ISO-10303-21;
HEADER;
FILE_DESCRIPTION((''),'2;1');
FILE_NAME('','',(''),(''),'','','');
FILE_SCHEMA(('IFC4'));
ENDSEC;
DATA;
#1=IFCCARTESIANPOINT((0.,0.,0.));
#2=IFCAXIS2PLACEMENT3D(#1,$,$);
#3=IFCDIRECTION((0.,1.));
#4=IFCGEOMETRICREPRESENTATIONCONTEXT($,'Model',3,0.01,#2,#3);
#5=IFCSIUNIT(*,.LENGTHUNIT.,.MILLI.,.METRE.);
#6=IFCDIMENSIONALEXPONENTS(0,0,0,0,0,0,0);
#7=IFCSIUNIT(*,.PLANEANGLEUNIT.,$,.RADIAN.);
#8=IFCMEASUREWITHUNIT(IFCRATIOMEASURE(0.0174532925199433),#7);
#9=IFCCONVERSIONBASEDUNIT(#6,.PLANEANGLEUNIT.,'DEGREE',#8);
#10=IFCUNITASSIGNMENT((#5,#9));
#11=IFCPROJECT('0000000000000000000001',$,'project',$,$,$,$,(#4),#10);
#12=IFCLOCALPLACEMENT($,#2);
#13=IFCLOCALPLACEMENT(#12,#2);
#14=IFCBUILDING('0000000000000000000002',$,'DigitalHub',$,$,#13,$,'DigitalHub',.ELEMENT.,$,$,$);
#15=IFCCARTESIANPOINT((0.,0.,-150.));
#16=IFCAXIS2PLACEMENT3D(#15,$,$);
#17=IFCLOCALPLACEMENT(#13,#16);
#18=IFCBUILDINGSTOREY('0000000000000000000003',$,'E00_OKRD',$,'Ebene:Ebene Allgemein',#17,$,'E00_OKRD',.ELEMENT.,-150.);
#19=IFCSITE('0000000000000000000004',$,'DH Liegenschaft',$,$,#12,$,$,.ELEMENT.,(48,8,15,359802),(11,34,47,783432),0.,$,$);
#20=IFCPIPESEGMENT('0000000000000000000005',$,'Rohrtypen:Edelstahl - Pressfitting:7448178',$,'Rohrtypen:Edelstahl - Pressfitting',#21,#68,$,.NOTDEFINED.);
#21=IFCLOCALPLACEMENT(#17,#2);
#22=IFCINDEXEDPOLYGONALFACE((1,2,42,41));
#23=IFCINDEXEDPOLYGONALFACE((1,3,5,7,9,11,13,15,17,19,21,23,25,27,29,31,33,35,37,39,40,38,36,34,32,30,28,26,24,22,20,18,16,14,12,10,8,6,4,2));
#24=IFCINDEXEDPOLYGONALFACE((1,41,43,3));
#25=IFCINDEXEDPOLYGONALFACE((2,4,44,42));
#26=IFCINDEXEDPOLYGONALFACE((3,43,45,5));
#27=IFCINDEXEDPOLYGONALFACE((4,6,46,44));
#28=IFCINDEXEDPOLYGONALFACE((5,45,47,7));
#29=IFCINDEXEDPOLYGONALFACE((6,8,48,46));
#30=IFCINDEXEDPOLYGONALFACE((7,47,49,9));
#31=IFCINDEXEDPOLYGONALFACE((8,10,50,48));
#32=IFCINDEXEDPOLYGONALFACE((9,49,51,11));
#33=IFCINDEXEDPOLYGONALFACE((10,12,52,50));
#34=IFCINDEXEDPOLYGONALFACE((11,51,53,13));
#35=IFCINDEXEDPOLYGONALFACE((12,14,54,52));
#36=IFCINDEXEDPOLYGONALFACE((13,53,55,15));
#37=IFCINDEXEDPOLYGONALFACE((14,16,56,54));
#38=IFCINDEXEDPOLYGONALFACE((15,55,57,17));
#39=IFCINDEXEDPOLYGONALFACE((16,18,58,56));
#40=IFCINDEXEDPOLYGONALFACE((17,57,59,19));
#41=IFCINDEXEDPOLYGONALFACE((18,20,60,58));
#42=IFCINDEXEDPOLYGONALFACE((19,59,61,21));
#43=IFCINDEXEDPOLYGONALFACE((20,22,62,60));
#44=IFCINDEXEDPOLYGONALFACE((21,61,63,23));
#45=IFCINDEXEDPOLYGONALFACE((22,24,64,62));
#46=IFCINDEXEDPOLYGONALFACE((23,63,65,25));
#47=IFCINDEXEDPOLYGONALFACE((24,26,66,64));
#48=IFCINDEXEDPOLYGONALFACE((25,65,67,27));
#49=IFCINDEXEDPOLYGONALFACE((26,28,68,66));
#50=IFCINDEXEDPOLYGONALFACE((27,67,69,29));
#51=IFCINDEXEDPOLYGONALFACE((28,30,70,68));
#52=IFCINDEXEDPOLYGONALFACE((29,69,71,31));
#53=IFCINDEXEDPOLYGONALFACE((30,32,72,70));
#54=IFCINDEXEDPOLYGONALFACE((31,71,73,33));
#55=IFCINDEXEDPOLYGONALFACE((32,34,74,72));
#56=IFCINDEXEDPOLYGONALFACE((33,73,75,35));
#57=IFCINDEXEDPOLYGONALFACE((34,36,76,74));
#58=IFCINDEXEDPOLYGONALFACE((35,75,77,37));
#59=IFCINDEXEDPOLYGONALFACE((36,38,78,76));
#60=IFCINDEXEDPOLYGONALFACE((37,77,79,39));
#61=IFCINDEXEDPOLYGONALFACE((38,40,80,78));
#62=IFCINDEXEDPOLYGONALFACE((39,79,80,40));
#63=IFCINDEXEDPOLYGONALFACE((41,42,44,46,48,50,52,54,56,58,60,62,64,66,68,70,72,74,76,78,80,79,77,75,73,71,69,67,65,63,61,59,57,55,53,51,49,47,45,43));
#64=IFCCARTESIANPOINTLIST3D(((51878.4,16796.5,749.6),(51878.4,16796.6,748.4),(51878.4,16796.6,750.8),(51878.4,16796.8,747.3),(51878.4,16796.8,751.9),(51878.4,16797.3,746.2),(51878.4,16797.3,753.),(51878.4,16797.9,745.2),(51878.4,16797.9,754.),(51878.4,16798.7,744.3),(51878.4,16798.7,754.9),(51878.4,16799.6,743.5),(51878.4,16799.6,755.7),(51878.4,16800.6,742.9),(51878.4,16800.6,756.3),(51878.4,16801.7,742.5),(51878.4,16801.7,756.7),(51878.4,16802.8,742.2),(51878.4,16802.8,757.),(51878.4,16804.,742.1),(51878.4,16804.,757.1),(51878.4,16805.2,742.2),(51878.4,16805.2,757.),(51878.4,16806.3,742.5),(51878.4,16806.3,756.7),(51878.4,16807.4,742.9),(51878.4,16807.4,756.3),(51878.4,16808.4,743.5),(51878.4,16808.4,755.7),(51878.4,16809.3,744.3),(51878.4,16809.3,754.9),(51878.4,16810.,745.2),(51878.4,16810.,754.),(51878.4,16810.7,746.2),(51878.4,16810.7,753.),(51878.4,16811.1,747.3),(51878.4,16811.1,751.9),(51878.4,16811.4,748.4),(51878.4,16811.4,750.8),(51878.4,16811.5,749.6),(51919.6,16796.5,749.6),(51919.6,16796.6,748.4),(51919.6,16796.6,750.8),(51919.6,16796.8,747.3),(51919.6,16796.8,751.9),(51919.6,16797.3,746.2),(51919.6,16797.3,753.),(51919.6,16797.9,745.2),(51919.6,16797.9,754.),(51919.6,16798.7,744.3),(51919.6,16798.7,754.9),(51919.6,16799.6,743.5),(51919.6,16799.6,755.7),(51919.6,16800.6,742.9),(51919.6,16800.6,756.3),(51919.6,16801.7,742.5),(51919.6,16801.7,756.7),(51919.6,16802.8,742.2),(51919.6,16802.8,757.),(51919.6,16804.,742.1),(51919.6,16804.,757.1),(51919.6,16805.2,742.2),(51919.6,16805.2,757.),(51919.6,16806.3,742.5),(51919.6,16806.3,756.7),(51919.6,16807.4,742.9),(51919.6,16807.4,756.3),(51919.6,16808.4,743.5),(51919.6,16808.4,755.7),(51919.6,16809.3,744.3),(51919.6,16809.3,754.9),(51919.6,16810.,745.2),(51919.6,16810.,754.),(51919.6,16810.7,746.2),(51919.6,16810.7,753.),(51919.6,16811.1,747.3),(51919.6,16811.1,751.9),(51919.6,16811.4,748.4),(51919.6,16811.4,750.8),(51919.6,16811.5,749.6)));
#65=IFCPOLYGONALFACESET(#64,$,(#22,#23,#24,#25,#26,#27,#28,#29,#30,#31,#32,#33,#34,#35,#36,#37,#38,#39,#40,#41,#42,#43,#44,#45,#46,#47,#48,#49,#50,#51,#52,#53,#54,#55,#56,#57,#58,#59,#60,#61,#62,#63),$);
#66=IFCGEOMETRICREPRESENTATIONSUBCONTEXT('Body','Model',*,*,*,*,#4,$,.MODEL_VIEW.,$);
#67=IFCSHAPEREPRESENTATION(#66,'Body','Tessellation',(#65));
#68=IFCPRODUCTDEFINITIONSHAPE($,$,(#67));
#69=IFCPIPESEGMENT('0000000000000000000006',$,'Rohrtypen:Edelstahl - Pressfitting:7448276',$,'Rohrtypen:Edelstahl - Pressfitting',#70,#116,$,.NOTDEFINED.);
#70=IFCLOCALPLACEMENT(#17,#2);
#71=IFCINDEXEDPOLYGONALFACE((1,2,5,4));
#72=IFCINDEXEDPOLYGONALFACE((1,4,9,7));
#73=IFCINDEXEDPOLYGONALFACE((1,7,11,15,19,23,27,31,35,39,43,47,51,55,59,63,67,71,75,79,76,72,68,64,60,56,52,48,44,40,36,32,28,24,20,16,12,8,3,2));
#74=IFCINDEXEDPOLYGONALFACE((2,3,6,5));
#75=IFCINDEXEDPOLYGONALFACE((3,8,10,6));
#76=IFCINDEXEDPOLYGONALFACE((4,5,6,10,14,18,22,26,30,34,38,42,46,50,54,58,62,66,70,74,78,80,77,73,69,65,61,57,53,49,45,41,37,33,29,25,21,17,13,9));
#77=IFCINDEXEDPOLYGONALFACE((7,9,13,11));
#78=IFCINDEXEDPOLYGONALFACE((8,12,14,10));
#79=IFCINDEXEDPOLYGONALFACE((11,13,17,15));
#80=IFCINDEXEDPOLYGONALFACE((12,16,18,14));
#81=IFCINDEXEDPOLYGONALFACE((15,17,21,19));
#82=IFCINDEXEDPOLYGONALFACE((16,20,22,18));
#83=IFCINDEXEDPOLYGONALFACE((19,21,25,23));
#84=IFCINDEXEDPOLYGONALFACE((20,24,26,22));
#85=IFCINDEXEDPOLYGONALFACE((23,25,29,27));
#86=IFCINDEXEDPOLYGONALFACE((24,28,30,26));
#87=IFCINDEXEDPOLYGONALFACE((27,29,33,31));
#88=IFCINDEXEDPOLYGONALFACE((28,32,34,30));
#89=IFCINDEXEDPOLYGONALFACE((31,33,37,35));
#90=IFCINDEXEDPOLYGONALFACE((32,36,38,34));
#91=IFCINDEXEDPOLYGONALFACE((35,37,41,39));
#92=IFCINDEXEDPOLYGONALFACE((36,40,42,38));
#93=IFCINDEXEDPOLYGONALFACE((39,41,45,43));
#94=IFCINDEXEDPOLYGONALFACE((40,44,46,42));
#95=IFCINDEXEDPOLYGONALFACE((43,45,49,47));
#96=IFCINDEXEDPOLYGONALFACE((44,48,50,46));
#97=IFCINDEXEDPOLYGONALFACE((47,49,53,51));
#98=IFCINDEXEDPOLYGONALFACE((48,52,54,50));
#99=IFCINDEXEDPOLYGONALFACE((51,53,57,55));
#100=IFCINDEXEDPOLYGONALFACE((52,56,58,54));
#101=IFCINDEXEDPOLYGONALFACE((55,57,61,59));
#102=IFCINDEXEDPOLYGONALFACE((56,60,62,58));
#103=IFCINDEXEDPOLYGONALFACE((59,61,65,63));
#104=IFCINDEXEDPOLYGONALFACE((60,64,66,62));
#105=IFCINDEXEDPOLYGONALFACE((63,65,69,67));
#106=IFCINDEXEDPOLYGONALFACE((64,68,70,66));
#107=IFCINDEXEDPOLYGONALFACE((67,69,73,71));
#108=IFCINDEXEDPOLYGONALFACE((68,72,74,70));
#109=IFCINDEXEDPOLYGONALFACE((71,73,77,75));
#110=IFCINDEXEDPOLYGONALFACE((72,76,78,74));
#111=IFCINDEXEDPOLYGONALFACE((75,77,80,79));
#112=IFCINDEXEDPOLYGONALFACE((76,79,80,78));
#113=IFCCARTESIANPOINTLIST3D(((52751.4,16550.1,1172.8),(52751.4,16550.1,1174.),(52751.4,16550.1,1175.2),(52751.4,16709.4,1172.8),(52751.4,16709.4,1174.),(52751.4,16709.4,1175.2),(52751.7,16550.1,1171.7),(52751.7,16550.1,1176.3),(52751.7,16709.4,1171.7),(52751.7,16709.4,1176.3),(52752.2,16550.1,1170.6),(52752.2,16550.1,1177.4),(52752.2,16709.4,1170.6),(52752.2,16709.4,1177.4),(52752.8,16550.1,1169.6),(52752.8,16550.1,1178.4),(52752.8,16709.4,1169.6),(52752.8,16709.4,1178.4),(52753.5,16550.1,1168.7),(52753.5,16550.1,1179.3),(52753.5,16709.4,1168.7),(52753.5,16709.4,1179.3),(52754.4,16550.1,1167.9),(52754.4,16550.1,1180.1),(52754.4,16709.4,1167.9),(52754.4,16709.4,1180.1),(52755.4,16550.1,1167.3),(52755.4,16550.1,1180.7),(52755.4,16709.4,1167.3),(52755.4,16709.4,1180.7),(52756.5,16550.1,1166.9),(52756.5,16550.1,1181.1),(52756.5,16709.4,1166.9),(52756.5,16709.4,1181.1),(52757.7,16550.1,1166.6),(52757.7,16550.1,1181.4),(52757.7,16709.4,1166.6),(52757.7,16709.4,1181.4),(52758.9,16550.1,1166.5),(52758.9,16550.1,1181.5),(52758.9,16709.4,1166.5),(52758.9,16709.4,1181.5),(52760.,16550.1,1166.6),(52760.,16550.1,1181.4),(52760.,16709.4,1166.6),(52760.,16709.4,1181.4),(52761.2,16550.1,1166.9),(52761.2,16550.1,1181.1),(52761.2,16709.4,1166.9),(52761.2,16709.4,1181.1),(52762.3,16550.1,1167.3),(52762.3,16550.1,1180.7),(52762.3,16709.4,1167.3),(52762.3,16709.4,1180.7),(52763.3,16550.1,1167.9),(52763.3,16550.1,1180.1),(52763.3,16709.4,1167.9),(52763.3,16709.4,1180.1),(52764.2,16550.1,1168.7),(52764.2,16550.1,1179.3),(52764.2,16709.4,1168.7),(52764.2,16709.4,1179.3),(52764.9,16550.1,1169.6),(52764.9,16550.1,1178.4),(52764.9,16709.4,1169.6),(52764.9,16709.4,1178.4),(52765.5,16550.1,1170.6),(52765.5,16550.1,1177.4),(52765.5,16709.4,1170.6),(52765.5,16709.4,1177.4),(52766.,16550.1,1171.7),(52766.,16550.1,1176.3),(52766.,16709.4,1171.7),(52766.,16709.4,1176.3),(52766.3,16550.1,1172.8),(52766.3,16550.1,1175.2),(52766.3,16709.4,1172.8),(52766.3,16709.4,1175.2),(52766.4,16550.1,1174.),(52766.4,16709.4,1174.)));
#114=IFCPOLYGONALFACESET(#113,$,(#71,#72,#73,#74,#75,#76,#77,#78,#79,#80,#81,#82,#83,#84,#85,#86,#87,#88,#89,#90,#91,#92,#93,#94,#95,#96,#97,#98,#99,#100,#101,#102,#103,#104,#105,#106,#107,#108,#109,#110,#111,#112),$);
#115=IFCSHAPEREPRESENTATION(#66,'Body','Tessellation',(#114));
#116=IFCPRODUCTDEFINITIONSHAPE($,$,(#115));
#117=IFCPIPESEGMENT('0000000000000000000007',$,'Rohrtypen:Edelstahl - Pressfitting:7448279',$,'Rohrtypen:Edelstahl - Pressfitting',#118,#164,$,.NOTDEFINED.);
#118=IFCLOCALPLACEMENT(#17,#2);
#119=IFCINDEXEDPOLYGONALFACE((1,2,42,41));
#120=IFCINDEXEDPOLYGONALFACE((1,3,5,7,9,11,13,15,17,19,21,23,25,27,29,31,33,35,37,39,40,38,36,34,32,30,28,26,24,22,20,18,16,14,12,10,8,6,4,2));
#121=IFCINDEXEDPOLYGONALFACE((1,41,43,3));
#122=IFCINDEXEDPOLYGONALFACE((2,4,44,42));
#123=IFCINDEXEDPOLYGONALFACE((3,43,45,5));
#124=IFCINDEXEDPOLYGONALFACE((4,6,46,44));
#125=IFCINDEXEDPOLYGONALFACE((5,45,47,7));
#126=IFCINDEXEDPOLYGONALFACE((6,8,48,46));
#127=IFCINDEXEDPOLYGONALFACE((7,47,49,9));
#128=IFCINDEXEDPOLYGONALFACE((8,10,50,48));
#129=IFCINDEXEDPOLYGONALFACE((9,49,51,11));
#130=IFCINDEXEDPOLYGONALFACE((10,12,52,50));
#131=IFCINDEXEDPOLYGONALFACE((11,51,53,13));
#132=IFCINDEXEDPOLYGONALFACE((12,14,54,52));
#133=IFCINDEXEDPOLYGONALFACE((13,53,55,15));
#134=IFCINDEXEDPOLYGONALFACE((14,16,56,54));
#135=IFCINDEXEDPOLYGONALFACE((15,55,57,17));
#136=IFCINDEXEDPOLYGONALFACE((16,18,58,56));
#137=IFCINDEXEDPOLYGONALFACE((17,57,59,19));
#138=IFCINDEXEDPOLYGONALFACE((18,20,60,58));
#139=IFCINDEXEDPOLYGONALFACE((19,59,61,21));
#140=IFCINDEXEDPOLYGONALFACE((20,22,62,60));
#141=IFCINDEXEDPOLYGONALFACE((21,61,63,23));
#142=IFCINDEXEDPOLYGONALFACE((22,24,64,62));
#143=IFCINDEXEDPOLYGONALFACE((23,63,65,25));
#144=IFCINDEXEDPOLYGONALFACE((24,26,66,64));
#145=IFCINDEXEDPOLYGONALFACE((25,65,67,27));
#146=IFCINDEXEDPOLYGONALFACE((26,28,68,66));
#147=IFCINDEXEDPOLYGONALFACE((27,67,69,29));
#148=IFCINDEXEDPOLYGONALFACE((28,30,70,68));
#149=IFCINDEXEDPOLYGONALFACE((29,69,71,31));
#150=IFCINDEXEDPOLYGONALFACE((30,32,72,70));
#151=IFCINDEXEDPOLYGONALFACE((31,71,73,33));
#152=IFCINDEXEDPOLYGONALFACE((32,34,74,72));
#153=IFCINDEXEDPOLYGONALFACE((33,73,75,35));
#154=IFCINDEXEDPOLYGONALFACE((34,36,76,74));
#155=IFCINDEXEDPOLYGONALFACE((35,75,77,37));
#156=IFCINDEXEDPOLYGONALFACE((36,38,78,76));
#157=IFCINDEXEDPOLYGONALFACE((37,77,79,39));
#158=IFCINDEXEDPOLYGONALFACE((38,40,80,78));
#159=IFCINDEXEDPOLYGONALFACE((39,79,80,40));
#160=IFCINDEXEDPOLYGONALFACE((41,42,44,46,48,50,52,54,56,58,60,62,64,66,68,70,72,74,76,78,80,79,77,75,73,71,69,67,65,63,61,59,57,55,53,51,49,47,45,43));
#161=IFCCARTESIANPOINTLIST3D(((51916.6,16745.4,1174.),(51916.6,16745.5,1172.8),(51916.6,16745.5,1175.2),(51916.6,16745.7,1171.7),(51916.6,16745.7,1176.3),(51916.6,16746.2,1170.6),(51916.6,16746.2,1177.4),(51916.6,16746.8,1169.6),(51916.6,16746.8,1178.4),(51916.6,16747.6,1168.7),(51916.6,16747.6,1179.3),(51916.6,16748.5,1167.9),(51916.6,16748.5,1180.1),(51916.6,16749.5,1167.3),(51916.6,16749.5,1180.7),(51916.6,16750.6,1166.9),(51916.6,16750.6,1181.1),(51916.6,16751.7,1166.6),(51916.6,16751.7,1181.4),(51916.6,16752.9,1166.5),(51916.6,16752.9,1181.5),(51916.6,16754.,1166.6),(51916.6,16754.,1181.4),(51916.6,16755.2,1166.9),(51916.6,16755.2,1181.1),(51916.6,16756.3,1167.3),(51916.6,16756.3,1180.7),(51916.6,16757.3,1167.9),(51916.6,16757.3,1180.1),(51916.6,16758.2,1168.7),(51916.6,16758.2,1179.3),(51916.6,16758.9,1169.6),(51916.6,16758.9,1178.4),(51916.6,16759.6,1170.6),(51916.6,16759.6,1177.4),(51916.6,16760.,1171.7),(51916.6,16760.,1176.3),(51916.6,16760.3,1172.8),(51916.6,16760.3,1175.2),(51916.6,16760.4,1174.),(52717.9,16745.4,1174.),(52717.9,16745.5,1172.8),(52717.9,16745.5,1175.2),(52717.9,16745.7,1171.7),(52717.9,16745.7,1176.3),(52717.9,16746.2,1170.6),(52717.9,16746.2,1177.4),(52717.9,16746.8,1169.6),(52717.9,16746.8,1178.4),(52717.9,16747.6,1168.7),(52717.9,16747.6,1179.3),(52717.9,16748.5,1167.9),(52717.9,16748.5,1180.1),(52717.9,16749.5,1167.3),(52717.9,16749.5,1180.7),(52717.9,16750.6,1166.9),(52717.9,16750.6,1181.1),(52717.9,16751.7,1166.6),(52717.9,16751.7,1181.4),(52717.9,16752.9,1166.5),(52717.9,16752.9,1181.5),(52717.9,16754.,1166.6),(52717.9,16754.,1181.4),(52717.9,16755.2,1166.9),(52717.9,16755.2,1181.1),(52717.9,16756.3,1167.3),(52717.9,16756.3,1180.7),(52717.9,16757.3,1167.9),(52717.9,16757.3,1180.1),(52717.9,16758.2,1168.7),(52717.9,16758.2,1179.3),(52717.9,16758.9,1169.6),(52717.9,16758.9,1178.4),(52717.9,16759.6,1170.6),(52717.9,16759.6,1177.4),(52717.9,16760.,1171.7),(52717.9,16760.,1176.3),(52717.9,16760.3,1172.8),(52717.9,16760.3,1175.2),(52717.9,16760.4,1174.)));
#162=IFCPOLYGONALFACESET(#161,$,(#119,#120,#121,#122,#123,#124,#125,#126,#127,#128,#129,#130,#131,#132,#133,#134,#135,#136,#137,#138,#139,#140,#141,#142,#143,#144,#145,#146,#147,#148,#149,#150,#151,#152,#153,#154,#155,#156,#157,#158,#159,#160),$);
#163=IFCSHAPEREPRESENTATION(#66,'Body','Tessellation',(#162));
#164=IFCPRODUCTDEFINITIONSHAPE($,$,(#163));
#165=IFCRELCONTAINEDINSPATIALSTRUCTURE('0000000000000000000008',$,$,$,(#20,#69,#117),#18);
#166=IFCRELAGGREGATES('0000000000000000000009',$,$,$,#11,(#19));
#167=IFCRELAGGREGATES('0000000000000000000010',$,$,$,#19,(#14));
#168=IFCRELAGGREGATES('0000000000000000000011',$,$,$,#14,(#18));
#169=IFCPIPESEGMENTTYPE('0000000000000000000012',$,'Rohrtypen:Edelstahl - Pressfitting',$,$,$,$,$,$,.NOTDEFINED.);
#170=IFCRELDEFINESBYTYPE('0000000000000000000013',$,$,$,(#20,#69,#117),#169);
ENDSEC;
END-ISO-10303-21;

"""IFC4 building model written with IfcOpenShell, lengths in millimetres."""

from ifc_helpers import new_model, entity, si_unit, converted_unit, direction, frame, origin, place, context, subcontext, project, spatial, indexed_curve, outline, extrude, type_object, element, save


model = new_model("IFC4")

# Units and contexts
model_context = context("Model", 3, precision=0.01, world=origin(), true_north=direction((0.0, 1.0)))
body_context = subcontext(model_context, "Body", "Model", "MODEL_VIEW")
ifc_project = project(units=[si_unit("LENGTHUNIT", "METRE", prefix="MILLI"), converted_unit("PLANEANGLEUNIT", "DEGREE", entity("IfcRatioMeasure", 0.0174532925199433), si_unit("PLANEANGLEUNIT", "RADIAN"), dimensions=[0, 0, 0, 0, 0, 0, 0])], contexts=[model_context])

# Site, building, storey
site_placement = place(None, origin())
site = spatial("IfcSite", under=ifc_project, at=site_placement, Name="DH Liegenschaft", CompositionType="ELEMENT", RefLatitude=(48, 8, 15, 359802), RefLongitude=(11, 34, 47, 783432), RefElevation=0.0)
building_placement = place(site_placement, origin())
building = spatial("IfcBuilding", under=site, at=building_placement, Name="DigitalHub", LongName="DigitalHub", CompositionType="ELEMENT")
storey_placement = place(building_placement, frame((0.0, 0.0, -150.0)))
storey = spatial("IfcBuildingStorey", under=building, at=storey_placement, Name="E00_OKRD", ObjectType="Ebene:Ebene Allgemein", LongName="E00_OKRD", CompositionType="ELEMENT", Elevation=-150.0)

# Pipe segments
pipe_segment_type_1 = type_object("IfcPipeSegmentType", Name="Rohrtypen:Edelstahl - Pressfitting", PredefinedType="NOTDEFINED")
pipe_segment_1_placement = place(storey_placement, frame((51878.4, 16794.9, 740.5)))
element("IfcPipeSegment", 1, at=pipe_segment_1_placement, inside=storey, type_object=pipe_segment_type_1, Name="Rohrtypen:Edelstahl - Pressfitting:7448178", ObjectType="Rohrtypen:Edelstahl - Pressfitting", PredefinedType="NOTDEFINED", context=body_context, shape_type="SweptSolid", body=[
    extrude(outline(indexed_curve([(7.5, 0.0), (7.4, 1.2), (7.1, 2.3), (6.7, 3.4), (6.1, 4.4), (5.3, 5.3), (4.4, 6.1), (3.4, 6.7), (2.3, 7.1), (1.2, 7.4), (0.0, 7.5), (-1.2, 7.4), (-2.3, 7.1), (-3.4, 6.7), (-4.4, 6.1), (-5.3, 5.3), (-6.1, 4.4), (-6.7, 3.4), (-7.1, 2.3), (-7.4, 1.2), (-7.5, 0.0), (-7.4, -1.2), (-7.1, -2.3), (-6.7, -3.4), (-6.1, -4.4), (-5.3, -5.3), (-4.4, -6.1), (-3.4, -6.7), (-2.3, -7.1), (-1.2, -7.4), (0.0, -7.5), (1.2, -7.4), (2.3, -7.1), (3.4, -6.7), (4.4, -6.1), (5.3, -5.3), (6.1, -4.4), (6.7, -3.4), (7.1, -2.3), (7.4, -1.2), (7.5, 0.0)], self_intersect=False)), frame((0.0, 9.1, 9.1), z_axis=(1.0, 0.0, 0.0), x_axis=(0.0, 1.0, 0.0)), (0.0, 0.0, 1.0), 41.2),
])
pipe_segment_2_placement = place(storey_placement, frame((52749.8, 16550.1, 1164.9)))
element("IfcPipeSegment", 2, at=pipe_segment_2_placement, inside=storey, type_object=pipe_segment_type_1, Name="Rohrtypen:Edelstahl - Pressfitting:7448276", ObjectType="Rohrtypen:Edelstahl - Pressfitting", PredefinedType="NOTDEFINED", context=body_context, shape_type="SweptSolid", body=[
    extrude(outline(indexed_curve([(7.5, 0.0), (7.4, 1.2), (7.1, 2.3), (6.7, 3.4), (6.1, 4.4), (5.3, 5.3), (4.4, 6.1), (3.4, 6.7), (2.3, 7.1), (1.2, 7.4), (0.0, 7.5), (-1.2, 7.4), (-2.3, 7.1), (-3.4, 6.7), (-4.4, 6.1), (-5.3, 5.3), (-6.1, 4.4), (-6.7, 3.4), (-7.1, 2.3), (-7.4, 1.2), (-7.5, 0.0), (-7.4, -1.2), (-7.1, -2.3), (-6.7, -3.4), (-6.1, -4.4), (-5.3, -5.3), (-4.4, -6.1), (-3.4, -6.7), (-2.3, -7.1), (-1.2, -7.4), (0.0, -7.5), (1.2, -7.4), (2.3, -7.1), (3.4, -6.7), (4.4, -6.1), (5.3, -5.3), (6.1, -4.4), (6.7, -3.4), (7.1, -2.3), (7.4, -1.2), (7.5, 0.0)], self_intersect=False)), frame((9.1, 0.0, 9.1), z_axis=(0.0, 1.0, 0.000047), x_axis=(-1.0, 0.0, 0.0)), (0.0, 0.0, 1.0), 159.2),
])
pipe_segment_3_placement = place(storey_placement, frame((51916.6, 16743.8, 1164.9)))
element("IfcPipeSegment", 3, at=pipe_segment_3_placement, inside=storey, type_object=pipe_segment_type_1, Name="Rohrtypen:Edelstahl - Pressfitting:7448279", ObjectType="Rohrtypen:Edelstahl - Pressfitting", PredefinedType="NOTDEFINED", context=body_context, shape_type="SweptSolid", body=[
    extrude(outline(indexed_curve([(7.5, 0.0), (7.4, 1.2), (7.1, 2.3), (6.7, 3.4), (6.1, 4.4), (5.3, 5.3), (4.4, 6.1), (3.4, 6.7), (2.3, 7.1), (1.2, 7.4), (0.0, 7.5), (-1.2, 7.4), (-2.3, 7.1), (-3.4, 6.7), (-4.4, 6.1), (-5.3, 5.3), (-6.1, 4.4), (-6.7, 3.4), (-7.1, 2.3), (-7.4, 1.2), (-7.5, 0.0), (-7.4, -1.2), (-7.1, -2.3), (-6.7, -3.4), (-6.1, -4.4), (-5.3, -5.3), (-4.4, -6.1), (-3.4, -6.7), (-2.3, -7.1), (-1.2, -7.4), (0.0, -7.5), (1.2, -7.4), (2.3, -7.1), (3.4, -6.7), (4.4, -6.1), (5.3, -5.3), (6.1, -4.4), (6.7, -3.4), (7.1, -2.3), (7.4, -1.2), (7.5, 0.0)], self_intersect=False)), frame((0.0, 9.1, 9.1), z_axis=(1.0, 0.0, 0.000011), x_axis=(0.0, -1.0, 0.0)), (0.0, 0.0, 1.0), 801.3),
])

save(model, "model.ifc")
